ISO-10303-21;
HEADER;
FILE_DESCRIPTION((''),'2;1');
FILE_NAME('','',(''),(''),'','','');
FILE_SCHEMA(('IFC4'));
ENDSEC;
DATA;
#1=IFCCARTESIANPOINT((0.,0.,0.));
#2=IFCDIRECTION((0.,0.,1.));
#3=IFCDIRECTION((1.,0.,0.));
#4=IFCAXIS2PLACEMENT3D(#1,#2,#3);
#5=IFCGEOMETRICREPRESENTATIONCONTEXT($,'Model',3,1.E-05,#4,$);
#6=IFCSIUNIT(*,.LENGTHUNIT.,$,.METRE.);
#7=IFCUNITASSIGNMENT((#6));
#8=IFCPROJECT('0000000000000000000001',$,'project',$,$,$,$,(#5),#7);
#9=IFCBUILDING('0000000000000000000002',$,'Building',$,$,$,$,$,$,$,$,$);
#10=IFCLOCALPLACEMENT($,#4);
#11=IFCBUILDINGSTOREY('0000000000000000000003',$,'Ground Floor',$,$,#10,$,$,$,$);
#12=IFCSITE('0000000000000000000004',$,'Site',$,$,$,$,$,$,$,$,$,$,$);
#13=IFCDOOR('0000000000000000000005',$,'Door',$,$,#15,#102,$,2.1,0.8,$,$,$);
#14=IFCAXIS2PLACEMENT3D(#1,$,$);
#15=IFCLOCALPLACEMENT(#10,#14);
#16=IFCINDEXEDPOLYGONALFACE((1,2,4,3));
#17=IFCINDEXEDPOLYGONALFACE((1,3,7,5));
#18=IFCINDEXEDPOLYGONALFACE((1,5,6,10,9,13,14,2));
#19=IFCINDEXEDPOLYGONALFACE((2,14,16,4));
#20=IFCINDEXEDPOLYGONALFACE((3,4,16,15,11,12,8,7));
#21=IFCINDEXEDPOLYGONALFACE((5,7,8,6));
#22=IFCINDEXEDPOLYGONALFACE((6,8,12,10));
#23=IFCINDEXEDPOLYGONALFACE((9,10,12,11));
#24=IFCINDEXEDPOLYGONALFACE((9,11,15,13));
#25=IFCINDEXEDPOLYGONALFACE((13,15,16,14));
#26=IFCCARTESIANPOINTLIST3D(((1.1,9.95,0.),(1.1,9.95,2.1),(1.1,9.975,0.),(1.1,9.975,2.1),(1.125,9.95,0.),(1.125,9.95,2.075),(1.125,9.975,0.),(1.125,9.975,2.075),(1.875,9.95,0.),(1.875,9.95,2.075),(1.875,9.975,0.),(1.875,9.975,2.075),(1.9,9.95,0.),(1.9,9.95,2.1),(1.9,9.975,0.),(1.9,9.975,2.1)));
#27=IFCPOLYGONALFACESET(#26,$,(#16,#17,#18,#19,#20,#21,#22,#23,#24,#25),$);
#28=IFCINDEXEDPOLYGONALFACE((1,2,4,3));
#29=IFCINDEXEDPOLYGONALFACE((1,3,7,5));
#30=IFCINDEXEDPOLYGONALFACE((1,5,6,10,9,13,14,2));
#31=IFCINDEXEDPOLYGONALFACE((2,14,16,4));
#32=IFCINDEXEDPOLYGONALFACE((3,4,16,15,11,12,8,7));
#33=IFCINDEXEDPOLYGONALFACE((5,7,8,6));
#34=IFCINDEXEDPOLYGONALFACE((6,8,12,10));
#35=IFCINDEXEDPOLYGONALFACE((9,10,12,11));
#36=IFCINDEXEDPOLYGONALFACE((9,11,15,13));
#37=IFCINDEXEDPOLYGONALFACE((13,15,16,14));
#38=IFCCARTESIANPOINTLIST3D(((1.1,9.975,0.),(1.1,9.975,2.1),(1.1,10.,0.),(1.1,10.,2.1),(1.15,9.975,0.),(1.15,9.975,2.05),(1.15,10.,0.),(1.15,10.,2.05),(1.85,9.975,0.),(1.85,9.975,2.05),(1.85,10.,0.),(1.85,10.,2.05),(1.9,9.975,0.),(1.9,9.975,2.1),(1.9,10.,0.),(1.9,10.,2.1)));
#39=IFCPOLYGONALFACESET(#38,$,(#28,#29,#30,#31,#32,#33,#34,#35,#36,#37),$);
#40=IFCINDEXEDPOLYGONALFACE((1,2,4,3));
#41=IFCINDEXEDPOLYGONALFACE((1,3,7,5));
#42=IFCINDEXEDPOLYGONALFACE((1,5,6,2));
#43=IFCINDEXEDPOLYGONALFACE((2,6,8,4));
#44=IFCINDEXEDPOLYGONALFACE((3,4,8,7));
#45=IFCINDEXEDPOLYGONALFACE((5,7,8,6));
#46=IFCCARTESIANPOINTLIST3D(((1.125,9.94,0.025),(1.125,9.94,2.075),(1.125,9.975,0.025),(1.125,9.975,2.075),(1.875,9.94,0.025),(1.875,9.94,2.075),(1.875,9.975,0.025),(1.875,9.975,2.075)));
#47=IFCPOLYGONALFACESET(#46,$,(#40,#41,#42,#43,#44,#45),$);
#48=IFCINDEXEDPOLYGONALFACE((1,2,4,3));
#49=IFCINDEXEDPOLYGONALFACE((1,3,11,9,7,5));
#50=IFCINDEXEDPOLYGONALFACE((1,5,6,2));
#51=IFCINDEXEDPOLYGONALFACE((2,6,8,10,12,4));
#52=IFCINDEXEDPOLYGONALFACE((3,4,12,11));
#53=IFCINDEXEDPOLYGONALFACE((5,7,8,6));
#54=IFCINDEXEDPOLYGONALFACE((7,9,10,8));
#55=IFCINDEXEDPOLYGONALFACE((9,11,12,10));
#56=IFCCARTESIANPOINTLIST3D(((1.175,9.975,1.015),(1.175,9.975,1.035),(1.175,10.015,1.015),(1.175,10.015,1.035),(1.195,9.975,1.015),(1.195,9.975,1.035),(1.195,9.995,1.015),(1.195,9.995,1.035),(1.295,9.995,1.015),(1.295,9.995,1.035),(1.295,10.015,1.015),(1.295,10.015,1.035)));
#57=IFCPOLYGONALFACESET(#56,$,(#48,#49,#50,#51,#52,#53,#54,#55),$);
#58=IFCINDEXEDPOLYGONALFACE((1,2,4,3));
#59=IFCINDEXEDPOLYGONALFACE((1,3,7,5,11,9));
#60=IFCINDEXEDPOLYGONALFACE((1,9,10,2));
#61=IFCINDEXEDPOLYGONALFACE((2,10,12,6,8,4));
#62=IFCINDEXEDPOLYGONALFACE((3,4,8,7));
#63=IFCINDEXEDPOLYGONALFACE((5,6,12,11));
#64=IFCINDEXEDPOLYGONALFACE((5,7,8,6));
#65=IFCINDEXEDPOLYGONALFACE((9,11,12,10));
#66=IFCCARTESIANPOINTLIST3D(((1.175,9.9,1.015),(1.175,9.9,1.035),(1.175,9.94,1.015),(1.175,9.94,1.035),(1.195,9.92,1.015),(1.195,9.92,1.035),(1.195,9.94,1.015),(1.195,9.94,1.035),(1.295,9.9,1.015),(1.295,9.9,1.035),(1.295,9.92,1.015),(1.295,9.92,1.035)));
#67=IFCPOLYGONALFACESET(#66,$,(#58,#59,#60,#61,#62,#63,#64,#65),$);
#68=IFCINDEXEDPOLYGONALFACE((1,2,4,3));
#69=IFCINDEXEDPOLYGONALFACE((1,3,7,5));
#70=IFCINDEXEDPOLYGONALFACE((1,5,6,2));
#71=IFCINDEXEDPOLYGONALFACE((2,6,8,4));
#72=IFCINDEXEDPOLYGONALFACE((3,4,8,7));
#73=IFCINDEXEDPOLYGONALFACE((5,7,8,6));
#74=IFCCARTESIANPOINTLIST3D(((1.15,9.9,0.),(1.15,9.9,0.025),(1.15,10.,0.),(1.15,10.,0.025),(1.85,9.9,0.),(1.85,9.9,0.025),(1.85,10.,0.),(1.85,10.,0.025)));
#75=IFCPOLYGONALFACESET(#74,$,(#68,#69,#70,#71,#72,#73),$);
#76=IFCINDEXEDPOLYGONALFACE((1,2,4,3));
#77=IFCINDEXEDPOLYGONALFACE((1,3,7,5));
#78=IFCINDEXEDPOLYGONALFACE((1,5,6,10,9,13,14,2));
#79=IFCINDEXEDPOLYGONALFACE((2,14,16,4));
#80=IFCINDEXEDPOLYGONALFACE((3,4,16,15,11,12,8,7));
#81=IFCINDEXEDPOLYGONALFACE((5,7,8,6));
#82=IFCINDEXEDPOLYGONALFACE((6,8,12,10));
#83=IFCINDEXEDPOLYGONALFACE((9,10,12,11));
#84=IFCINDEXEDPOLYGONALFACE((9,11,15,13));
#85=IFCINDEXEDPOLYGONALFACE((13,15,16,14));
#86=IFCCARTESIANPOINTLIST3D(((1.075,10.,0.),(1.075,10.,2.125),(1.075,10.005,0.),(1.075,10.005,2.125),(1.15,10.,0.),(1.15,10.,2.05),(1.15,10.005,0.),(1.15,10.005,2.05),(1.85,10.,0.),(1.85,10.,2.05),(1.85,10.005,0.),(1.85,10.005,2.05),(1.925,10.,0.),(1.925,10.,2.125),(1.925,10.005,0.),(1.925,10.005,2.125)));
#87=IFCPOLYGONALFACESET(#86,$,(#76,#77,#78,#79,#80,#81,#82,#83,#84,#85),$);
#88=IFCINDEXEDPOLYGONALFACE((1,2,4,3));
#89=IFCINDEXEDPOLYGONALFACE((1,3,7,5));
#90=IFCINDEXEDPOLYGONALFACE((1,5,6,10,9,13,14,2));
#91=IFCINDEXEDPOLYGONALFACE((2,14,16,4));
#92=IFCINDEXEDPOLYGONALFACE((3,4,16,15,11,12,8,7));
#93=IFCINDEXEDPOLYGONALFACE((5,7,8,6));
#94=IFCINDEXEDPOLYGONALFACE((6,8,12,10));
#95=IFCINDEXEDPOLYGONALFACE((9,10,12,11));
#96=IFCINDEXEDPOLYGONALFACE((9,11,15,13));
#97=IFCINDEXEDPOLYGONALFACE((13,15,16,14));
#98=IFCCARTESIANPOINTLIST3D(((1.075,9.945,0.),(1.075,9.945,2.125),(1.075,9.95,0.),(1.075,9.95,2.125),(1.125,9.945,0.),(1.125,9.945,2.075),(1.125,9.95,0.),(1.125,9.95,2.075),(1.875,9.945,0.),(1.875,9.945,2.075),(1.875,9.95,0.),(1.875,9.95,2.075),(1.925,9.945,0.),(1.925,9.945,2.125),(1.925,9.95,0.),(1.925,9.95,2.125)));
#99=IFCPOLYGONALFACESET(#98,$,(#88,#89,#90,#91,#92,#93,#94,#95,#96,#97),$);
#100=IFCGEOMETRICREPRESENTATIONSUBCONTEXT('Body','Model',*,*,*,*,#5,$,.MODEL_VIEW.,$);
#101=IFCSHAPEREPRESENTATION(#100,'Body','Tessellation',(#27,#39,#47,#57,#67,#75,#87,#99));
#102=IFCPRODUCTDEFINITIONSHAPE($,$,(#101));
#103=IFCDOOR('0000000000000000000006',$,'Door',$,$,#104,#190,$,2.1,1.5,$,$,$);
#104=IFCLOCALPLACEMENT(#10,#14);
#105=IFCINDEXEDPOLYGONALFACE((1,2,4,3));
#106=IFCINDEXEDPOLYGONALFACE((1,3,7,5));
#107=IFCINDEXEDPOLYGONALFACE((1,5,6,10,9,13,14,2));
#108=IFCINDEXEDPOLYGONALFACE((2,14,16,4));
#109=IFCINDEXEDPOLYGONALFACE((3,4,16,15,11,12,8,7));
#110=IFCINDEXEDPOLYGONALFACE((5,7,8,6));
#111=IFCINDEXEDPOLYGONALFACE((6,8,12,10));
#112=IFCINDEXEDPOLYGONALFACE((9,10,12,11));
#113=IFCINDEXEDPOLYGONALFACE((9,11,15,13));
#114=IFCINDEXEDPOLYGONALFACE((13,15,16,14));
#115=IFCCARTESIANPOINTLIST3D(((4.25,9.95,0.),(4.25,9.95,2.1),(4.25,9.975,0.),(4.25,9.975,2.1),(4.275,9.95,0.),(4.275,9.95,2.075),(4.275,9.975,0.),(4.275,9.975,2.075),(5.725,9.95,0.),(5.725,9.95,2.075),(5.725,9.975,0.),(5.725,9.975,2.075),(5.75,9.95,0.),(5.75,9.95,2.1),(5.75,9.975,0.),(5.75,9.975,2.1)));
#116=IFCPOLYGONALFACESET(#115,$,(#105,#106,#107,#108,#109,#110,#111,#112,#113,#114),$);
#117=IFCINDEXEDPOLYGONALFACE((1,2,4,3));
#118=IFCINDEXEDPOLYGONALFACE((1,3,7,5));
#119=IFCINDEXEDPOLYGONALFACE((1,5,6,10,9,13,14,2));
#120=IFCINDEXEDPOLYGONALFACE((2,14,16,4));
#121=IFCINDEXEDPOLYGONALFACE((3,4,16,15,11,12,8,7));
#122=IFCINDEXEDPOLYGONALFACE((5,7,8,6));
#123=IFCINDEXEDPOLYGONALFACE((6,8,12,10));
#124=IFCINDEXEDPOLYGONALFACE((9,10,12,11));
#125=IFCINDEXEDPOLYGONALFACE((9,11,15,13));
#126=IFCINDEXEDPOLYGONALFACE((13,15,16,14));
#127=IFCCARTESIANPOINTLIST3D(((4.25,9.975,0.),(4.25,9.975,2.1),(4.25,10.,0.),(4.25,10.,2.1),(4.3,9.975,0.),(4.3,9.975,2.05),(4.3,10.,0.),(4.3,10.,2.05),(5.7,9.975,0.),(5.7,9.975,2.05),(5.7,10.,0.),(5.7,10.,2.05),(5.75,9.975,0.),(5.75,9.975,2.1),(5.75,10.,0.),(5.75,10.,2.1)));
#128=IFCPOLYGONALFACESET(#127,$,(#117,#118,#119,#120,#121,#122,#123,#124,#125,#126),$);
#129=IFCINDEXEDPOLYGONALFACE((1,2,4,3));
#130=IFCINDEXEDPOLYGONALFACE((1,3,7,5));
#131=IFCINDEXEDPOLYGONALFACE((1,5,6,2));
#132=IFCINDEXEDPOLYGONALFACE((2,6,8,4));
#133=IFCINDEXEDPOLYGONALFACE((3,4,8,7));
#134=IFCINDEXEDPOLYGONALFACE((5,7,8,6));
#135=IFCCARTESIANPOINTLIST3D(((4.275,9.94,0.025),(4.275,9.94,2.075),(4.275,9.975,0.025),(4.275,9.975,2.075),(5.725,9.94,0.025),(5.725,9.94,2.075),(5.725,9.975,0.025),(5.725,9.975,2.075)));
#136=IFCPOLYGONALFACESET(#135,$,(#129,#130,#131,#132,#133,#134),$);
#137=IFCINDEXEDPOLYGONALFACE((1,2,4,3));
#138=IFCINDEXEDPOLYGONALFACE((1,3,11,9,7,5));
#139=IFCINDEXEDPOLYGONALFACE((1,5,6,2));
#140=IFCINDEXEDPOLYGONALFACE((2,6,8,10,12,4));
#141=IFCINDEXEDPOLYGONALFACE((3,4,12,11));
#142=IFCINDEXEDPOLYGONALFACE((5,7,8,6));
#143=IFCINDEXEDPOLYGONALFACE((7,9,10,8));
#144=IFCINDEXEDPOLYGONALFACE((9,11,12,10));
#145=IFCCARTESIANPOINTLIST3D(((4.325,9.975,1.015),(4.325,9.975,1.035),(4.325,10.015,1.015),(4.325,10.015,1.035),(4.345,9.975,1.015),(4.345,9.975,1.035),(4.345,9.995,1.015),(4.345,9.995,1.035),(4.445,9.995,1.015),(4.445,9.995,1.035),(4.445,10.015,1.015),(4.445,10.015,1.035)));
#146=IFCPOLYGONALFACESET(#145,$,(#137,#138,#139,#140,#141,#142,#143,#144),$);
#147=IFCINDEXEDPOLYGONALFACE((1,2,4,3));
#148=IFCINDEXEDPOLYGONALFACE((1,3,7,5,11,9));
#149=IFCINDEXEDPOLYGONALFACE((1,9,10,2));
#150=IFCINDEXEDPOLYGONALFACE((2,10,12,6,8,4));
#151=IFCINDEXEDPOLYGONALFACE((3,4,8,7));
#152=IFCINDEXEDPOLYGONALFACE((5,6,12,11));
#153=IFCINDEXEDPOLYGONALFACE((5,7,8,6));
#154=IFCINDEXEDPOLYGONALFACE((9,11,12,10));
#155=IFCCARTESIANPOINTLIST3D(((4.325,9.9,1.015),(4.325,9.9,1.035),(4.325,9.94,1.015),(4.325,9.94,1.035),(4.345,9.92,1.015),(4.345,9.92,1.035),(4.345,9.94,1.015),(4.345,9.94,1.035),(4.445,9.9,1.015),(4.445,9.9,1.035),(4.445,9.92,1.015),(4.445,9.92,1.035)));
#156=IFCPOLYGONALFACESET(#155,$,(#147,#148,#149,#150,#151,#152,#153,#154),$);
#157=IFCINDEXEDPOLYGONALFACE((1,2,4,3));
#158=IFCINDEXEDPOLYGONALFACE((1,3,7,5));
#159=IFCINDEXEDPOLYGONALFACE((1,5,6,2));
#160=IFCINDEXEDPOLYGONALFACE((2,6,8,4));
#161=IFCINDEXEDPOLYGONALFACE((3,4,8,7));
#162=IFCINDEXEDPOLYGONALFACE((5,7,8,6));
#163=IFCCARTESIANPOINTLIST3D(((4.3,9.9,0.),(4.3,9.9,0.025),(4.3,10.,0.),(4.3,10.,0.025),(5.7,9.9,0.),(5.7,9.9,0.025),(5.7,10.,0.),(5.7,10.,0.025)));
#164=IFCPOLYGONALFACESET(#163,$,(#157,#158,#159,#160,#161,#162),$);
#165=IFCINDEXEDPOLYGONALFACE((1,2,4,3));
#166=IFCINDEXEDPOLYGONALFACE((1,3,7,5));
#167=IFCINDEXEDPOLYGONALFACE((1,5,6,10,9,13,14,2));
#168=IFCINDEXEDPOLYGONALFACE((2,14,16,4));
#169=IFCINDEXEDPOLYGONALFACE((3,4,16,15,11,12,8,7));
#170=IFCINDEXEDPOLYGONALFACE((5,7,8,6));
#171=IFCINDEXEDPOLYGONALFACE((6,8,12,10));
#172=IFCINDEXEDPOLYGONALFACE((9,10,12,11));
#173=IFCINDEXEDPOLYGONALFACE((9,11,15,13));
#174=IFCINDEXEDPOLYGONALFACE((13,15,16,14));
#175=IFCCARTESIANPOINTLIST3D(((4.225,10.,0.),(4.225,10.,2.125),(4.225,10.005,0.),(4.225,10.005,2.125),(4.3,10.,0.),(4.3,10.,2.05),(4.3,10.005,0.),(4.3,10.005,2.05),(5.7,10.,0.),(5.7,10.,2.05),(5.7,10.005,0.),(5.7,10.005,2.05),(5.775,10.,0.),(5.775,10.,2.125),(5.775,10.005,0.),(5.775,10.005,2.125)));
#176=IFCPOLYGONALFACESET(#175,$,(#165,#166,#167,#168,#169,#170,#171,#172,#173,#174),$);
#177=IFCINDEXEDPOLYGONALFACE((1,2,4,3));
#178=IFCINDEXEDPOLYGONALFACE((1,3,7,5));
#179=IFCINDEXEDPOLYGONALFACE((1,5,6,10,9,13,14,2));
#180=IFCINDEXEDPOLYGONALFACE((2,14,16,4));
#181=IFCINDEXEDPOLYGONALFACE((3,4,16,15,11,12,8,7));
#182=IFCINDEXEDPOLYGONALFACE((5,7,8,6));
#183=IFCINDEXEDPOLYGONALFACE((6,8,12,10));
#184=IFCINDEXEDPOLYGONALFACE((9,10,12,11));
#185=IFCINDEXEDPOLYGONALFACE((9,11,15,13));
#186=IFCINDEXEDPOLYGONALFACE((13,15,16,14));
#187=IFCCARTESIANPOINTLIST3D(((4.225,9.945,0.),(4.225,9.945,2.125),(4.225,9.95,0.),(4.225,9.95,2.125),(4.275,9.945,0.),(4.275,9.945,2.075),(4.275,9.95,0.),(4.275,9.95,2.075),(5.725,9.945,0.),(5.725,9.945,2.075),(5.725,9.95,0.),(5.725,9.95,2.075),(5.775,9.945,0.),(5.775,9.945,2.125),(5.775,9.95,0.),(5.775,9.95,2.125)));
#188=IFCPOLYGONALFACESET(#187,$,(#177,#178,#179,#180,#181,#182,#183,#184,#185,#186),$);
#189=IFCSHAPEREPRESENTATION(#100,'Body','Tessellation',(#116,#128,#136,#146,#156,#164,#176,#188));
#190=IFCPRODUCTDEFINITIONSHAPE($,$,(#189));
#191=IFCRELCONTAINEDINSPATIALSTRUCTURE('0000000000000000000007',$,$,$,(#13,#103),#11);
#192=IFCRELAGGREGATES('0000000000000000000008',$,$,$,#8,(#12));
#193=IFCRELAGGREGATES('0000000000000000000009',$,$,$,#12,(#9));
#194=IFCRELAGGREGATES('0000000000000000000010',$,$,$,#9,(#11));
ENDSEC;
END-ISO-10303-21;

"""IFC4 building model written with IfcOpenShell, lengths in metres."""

from ifc_helpers import new_model, si_unit, frame, origin_with_axes, place, context, subcontext, project, spatial, line, indexed_curve, outline, extrude, element, save


model = new_model("IFC4")

# Units and contexts
model_context = context("Model", 3, precision=1e-05, world=origin_with_axes())
body_context = subcontext(model_context, "Body", "Model", "MODEL_VIEW")
ifc_project = project(units=[si_unit("LENGTHUNIT", "METRE")], contexts=[model_context])

# Site, building, storey
site = spatial("IfcSite", under=ifc_project, Name="Site")
building = spatial("IfcBuilding", under=site, Name="Building")
storey_placement = place(None, origin_with_axes())
storey = spatial("IfcBuildingStorey", under=building, at=storey_placement, Name="Ground Floor")

# Doors
door_1_placement = place(storey_placement, frame((1.9, 10.0, 0.0), z_axis=(0.0, 0.0, 1.0), x_axis=(-1.0, 0.0, 0.0)))
element("IfcDoor", 1, at=door_1_placement, inside=storey, Name="Door", OverallHeight=2.1, OverallWidth=0.8, context=body_context, shape_type="SweptSolid", body=[
    extrude(outline(indexed_curve([(0.0, 0.0), (0.0, 2.1), (0.8, 2.1), (0.8, 0.0), (0.775, 0.0), (0.775, 2.075), (0.025, 2.075), (0.025, 0.0)], segments=[line(1, 2, 3, 4, 5, 6, 7, 8, 1)])), frame((0.0, 0.025, 0.0), z_axis=(0.0, -1.0, 0.0), x_axis=(1.0, 0.0, 0.0)), (0.0, 0.0, -1.0), 0.025),
    extrude(outline(indexed_curve([(0.0, 0.0), (0.0, 2.1), (0.8, 2.1), (0.8, 0.0), (0.75, 0.0), (0.75, 2.05), (0.05, 2.05), (0.05, 0.0)], segments=[line(1, 2, 3, 4, 5, 6, 7, 8, 1)])), frame((0.0, 0.0, 0.0), z_axis=(0.0, -1.0, 0.0), x_axis=(1.0, 0.0, 0.0)), (0.0, 0.0, -1.0), 0.025),
    extrude(outline(indexed_curve([(0.0, 0.0), (0.75, 0.0), (0.75, 0.035), (0.0, 0.035)], segments=[line(1, 2, 3, 4, 1)])), frame((0.025, 0.025, 0.025), z_axis=(0.0, 0.0, 1.0), x_axis=(1.0, 0.0, 0.0)), (0.0, 0.0, 1.0), 2.05),
    extrude(outline(indexed_curve([(0.0, 0.0), (0.0, -0.04), (-0.12, -0.04), (-0.12, -0.02), (-0.02, -0.02), (-0.02, 0.0)], segments=[line(1, 2, 3, 4, 5, 6, 1)])), frame((0.725, 0.025, 1.015), z_axis=(0.0, 0.0, 1.0), x_axis=(1.0, 0.0, 0.0)), (0.0, 0.0, 1.0), 0.02),
    extrude(outline(indexed_curve([(0.0, 0.0), (0.0, 0.04), (-0.12, 0.04), (-0.12, 0.02), (-0.02, 0.02), (-0.02, 0.0)], segments=[line(1, 2, 3, 4, 5, 6, 1)])), frame((0.725, 0.06, 1.015), z_axis=(0.0, 0.0, 1.0), x_axis=(1.0, 0.0, 0.0)), (0.0, 0.0, 1.0), 0.02),
    extrude(outline(indexed_curve([(0.0, 0.0), (0.7, 0.0), (0.7, 0.1), (0.0, 0.1)], segments=[line(1, 2, 3, 4, 1)])), frame((0.05, 0.0, 0.0), z_axis=(0.0, 0.0, 1.0), x_axis=(1.0, 0.0, 0.0)), (0.0, 0.0, 1.0), 0.025),
    extrude(outline(indexed_curve([(0.0, 0.0), (0.0, 2.125), (0.85, 2.125), (0.85, 0.0), (0.775, 0.0), (0.775, 2.05), (0.075, 2.05), (0.075, 0.0)], segments=[line(1, 2, 3, 4, 5, 6, 7, 8, 1)])), frame((-0.025, -0.005, 0.0), z_axis=(0.0, -1.0, 0.0), x_axis=(1.0, 0.0, 0.0)), (0.0, 0.0, -1.0), 0.005),
    extrude(outline(indexed_curve([(0.0, 0.0), (0.0, 2.125), (0.85, 2.125), (0.85, 0.0), (0.8, 0.0), (0.8, 2.075), (0.05, 2.075), (0.05, 0.0)], segments=[line(1, 2, 3, 4, 5, 6, 7, 8, 1)])), frame((-0.025, 0.05, 0.0), z_axis=(0.0, -1.0, 0.0), x_axis=(1.0, 0.0, 0.0)), (0.0, 0.0, -1.0), 0.005),
])
door_2_placement = place(storey_placement, frame((5.75, 10.0, 0.0), z_axis=(0.0, 0.0, 1.0), x_axis=(-1.0, 0.0, 0.0)))
element("IfcDoor", 2, at=door_2_placement, inside=storey, Name="Door", OverallHeight=2.1, OverallWidth=1.5, context=body_context, shape_type="SweptSolid", body=[
    extrude(outline(indexed_curve([(0.0, 0.0), (0.0, 2.1), (1.5, 2.1), (1.5, 0.0), (1.475, 0.0), (1.475, 2.075), (0.025, 2.075), (0.025, 0.0)], segments=[line(1, 2, 3, 4, 5, 6, 7, 8, 1)])), frame((0.0, 0.025, 0.0), z_axis=(0.0, -1.0, 0.0), x_axis=(1.0, 0.0, 0.0)), (0.0, 0.0, -1.0), 0.025),
    extrude(outline(indexed_curve([(0.0, 0.0), (0.0, 2.1), (1.5, 2.1), (1.5, 0.0), (1.45, 0.0), (1.45, 2.05), (0.05, 2.05), (0.05, 0.0)], segments=[line(1, 2, 3, 4, 5, 6, 7, 8, 1)])), frame((0.0, 0.0, 0.0), z_axis=(0.0, -1.0, 0.0), x_axis=(1.0, 0.0, 0.0)), (0.0, 0.0, -1.0), 0.025),
    extrude(outline(indexed_curve([(0.0, 0.0), (1.45, 0.0), (1.45, 0.035), (0.0, 0.035)], segments=[line(1, 2, 3, 4, 1)])), frame((0.025, 0.025, 0.025), z_axis=(0.0, 0.0, 1.0), x_axis=(1.0, 0.0, 0.0)), (0.0, 0.0, 1.0), 2.05),
    extrude(outline(indexed_curve([(0.0, 0.0), (0.0, -0.04), (-0.12, -0.04), (-0.12, -0.02), (-0.02, -0.02), (-0.02, 0.0)], segments=[line(1, 2, 3, 4, 5, 6, 1)])), frame((1.425, 0.025, 1.015), z_axis=(0.0, 0.0, 1.0), x_axis=(1.0, 0.0, 0.0)), (0.0, 0.0, 1.0), 0.02),
    extrude(outline(indexed_curve([(0.0, 0.0), (0.0, 0.04), (-0.12, 0.04), (-0.12, 0.02), (-0.02, 0.02), (-0.02, 0.0)], segments=[line(1, 2, 3, 4, 5, 6, 1)])), frame((1.425, 0.06, 1.015), z_axis=(0.0, 0.0, 1.0), x_axis=(1.0, 0.0, 0.0)), (0.0, 0.0, 1.0), 0.02),
    extrude(outline(indexed_curve([(0.0, 0.0), (1.4, 0.0), (1.4, 0.1), (0.0, 0.1)], segments=[line(1, 2, 3, 4, 1)])), frame((0.05, 0.0, 0.0), z_axis=(0.0, 0.0, 1.0), x_axis=(1.0, 0.0, 0.0)), (0.0, 0.0, 1.0), 0.025),
    extrude(outline(indexed_curve([(0.0, 0.0), (0.0, 2.125), (1.55, 2.125), (1.55, 0.0), (1.475, 0.0), (1.475, 2.05), (0.075, 2.05), (0.075, 0.0)], segments=[line(1, 2, 3, 4, 5, 6, 7, 8, 1)])), frame((-0.025, -0.005, 0.0), z_axis=(0.0, -1.0, 0.0), x_axis=(1.0, 0.0, 0.0)), (0.0, 0.0, -1.0), 0.005),
    extrude(outline(indexed_curve([(0.0, 0.0), (0.0, 2.125), (1.55, 2.125), (1.55, 0.0), (1.5, 0.0), (1.5, 2.075), (0.05, 2.075), (0.05, 0.0)], segments=[line(1, 2, 3, 4, 5, 6, 7, 8, 1)])), frame((-0.025, 0.05, 0.0), z_axis=(0.0, -1.0, 0.0), x_axis=(1.0, 0.0, 0.0)), (0.0, 0.0, -1.0), 0.005),
])

save(model, "model.ifc")
